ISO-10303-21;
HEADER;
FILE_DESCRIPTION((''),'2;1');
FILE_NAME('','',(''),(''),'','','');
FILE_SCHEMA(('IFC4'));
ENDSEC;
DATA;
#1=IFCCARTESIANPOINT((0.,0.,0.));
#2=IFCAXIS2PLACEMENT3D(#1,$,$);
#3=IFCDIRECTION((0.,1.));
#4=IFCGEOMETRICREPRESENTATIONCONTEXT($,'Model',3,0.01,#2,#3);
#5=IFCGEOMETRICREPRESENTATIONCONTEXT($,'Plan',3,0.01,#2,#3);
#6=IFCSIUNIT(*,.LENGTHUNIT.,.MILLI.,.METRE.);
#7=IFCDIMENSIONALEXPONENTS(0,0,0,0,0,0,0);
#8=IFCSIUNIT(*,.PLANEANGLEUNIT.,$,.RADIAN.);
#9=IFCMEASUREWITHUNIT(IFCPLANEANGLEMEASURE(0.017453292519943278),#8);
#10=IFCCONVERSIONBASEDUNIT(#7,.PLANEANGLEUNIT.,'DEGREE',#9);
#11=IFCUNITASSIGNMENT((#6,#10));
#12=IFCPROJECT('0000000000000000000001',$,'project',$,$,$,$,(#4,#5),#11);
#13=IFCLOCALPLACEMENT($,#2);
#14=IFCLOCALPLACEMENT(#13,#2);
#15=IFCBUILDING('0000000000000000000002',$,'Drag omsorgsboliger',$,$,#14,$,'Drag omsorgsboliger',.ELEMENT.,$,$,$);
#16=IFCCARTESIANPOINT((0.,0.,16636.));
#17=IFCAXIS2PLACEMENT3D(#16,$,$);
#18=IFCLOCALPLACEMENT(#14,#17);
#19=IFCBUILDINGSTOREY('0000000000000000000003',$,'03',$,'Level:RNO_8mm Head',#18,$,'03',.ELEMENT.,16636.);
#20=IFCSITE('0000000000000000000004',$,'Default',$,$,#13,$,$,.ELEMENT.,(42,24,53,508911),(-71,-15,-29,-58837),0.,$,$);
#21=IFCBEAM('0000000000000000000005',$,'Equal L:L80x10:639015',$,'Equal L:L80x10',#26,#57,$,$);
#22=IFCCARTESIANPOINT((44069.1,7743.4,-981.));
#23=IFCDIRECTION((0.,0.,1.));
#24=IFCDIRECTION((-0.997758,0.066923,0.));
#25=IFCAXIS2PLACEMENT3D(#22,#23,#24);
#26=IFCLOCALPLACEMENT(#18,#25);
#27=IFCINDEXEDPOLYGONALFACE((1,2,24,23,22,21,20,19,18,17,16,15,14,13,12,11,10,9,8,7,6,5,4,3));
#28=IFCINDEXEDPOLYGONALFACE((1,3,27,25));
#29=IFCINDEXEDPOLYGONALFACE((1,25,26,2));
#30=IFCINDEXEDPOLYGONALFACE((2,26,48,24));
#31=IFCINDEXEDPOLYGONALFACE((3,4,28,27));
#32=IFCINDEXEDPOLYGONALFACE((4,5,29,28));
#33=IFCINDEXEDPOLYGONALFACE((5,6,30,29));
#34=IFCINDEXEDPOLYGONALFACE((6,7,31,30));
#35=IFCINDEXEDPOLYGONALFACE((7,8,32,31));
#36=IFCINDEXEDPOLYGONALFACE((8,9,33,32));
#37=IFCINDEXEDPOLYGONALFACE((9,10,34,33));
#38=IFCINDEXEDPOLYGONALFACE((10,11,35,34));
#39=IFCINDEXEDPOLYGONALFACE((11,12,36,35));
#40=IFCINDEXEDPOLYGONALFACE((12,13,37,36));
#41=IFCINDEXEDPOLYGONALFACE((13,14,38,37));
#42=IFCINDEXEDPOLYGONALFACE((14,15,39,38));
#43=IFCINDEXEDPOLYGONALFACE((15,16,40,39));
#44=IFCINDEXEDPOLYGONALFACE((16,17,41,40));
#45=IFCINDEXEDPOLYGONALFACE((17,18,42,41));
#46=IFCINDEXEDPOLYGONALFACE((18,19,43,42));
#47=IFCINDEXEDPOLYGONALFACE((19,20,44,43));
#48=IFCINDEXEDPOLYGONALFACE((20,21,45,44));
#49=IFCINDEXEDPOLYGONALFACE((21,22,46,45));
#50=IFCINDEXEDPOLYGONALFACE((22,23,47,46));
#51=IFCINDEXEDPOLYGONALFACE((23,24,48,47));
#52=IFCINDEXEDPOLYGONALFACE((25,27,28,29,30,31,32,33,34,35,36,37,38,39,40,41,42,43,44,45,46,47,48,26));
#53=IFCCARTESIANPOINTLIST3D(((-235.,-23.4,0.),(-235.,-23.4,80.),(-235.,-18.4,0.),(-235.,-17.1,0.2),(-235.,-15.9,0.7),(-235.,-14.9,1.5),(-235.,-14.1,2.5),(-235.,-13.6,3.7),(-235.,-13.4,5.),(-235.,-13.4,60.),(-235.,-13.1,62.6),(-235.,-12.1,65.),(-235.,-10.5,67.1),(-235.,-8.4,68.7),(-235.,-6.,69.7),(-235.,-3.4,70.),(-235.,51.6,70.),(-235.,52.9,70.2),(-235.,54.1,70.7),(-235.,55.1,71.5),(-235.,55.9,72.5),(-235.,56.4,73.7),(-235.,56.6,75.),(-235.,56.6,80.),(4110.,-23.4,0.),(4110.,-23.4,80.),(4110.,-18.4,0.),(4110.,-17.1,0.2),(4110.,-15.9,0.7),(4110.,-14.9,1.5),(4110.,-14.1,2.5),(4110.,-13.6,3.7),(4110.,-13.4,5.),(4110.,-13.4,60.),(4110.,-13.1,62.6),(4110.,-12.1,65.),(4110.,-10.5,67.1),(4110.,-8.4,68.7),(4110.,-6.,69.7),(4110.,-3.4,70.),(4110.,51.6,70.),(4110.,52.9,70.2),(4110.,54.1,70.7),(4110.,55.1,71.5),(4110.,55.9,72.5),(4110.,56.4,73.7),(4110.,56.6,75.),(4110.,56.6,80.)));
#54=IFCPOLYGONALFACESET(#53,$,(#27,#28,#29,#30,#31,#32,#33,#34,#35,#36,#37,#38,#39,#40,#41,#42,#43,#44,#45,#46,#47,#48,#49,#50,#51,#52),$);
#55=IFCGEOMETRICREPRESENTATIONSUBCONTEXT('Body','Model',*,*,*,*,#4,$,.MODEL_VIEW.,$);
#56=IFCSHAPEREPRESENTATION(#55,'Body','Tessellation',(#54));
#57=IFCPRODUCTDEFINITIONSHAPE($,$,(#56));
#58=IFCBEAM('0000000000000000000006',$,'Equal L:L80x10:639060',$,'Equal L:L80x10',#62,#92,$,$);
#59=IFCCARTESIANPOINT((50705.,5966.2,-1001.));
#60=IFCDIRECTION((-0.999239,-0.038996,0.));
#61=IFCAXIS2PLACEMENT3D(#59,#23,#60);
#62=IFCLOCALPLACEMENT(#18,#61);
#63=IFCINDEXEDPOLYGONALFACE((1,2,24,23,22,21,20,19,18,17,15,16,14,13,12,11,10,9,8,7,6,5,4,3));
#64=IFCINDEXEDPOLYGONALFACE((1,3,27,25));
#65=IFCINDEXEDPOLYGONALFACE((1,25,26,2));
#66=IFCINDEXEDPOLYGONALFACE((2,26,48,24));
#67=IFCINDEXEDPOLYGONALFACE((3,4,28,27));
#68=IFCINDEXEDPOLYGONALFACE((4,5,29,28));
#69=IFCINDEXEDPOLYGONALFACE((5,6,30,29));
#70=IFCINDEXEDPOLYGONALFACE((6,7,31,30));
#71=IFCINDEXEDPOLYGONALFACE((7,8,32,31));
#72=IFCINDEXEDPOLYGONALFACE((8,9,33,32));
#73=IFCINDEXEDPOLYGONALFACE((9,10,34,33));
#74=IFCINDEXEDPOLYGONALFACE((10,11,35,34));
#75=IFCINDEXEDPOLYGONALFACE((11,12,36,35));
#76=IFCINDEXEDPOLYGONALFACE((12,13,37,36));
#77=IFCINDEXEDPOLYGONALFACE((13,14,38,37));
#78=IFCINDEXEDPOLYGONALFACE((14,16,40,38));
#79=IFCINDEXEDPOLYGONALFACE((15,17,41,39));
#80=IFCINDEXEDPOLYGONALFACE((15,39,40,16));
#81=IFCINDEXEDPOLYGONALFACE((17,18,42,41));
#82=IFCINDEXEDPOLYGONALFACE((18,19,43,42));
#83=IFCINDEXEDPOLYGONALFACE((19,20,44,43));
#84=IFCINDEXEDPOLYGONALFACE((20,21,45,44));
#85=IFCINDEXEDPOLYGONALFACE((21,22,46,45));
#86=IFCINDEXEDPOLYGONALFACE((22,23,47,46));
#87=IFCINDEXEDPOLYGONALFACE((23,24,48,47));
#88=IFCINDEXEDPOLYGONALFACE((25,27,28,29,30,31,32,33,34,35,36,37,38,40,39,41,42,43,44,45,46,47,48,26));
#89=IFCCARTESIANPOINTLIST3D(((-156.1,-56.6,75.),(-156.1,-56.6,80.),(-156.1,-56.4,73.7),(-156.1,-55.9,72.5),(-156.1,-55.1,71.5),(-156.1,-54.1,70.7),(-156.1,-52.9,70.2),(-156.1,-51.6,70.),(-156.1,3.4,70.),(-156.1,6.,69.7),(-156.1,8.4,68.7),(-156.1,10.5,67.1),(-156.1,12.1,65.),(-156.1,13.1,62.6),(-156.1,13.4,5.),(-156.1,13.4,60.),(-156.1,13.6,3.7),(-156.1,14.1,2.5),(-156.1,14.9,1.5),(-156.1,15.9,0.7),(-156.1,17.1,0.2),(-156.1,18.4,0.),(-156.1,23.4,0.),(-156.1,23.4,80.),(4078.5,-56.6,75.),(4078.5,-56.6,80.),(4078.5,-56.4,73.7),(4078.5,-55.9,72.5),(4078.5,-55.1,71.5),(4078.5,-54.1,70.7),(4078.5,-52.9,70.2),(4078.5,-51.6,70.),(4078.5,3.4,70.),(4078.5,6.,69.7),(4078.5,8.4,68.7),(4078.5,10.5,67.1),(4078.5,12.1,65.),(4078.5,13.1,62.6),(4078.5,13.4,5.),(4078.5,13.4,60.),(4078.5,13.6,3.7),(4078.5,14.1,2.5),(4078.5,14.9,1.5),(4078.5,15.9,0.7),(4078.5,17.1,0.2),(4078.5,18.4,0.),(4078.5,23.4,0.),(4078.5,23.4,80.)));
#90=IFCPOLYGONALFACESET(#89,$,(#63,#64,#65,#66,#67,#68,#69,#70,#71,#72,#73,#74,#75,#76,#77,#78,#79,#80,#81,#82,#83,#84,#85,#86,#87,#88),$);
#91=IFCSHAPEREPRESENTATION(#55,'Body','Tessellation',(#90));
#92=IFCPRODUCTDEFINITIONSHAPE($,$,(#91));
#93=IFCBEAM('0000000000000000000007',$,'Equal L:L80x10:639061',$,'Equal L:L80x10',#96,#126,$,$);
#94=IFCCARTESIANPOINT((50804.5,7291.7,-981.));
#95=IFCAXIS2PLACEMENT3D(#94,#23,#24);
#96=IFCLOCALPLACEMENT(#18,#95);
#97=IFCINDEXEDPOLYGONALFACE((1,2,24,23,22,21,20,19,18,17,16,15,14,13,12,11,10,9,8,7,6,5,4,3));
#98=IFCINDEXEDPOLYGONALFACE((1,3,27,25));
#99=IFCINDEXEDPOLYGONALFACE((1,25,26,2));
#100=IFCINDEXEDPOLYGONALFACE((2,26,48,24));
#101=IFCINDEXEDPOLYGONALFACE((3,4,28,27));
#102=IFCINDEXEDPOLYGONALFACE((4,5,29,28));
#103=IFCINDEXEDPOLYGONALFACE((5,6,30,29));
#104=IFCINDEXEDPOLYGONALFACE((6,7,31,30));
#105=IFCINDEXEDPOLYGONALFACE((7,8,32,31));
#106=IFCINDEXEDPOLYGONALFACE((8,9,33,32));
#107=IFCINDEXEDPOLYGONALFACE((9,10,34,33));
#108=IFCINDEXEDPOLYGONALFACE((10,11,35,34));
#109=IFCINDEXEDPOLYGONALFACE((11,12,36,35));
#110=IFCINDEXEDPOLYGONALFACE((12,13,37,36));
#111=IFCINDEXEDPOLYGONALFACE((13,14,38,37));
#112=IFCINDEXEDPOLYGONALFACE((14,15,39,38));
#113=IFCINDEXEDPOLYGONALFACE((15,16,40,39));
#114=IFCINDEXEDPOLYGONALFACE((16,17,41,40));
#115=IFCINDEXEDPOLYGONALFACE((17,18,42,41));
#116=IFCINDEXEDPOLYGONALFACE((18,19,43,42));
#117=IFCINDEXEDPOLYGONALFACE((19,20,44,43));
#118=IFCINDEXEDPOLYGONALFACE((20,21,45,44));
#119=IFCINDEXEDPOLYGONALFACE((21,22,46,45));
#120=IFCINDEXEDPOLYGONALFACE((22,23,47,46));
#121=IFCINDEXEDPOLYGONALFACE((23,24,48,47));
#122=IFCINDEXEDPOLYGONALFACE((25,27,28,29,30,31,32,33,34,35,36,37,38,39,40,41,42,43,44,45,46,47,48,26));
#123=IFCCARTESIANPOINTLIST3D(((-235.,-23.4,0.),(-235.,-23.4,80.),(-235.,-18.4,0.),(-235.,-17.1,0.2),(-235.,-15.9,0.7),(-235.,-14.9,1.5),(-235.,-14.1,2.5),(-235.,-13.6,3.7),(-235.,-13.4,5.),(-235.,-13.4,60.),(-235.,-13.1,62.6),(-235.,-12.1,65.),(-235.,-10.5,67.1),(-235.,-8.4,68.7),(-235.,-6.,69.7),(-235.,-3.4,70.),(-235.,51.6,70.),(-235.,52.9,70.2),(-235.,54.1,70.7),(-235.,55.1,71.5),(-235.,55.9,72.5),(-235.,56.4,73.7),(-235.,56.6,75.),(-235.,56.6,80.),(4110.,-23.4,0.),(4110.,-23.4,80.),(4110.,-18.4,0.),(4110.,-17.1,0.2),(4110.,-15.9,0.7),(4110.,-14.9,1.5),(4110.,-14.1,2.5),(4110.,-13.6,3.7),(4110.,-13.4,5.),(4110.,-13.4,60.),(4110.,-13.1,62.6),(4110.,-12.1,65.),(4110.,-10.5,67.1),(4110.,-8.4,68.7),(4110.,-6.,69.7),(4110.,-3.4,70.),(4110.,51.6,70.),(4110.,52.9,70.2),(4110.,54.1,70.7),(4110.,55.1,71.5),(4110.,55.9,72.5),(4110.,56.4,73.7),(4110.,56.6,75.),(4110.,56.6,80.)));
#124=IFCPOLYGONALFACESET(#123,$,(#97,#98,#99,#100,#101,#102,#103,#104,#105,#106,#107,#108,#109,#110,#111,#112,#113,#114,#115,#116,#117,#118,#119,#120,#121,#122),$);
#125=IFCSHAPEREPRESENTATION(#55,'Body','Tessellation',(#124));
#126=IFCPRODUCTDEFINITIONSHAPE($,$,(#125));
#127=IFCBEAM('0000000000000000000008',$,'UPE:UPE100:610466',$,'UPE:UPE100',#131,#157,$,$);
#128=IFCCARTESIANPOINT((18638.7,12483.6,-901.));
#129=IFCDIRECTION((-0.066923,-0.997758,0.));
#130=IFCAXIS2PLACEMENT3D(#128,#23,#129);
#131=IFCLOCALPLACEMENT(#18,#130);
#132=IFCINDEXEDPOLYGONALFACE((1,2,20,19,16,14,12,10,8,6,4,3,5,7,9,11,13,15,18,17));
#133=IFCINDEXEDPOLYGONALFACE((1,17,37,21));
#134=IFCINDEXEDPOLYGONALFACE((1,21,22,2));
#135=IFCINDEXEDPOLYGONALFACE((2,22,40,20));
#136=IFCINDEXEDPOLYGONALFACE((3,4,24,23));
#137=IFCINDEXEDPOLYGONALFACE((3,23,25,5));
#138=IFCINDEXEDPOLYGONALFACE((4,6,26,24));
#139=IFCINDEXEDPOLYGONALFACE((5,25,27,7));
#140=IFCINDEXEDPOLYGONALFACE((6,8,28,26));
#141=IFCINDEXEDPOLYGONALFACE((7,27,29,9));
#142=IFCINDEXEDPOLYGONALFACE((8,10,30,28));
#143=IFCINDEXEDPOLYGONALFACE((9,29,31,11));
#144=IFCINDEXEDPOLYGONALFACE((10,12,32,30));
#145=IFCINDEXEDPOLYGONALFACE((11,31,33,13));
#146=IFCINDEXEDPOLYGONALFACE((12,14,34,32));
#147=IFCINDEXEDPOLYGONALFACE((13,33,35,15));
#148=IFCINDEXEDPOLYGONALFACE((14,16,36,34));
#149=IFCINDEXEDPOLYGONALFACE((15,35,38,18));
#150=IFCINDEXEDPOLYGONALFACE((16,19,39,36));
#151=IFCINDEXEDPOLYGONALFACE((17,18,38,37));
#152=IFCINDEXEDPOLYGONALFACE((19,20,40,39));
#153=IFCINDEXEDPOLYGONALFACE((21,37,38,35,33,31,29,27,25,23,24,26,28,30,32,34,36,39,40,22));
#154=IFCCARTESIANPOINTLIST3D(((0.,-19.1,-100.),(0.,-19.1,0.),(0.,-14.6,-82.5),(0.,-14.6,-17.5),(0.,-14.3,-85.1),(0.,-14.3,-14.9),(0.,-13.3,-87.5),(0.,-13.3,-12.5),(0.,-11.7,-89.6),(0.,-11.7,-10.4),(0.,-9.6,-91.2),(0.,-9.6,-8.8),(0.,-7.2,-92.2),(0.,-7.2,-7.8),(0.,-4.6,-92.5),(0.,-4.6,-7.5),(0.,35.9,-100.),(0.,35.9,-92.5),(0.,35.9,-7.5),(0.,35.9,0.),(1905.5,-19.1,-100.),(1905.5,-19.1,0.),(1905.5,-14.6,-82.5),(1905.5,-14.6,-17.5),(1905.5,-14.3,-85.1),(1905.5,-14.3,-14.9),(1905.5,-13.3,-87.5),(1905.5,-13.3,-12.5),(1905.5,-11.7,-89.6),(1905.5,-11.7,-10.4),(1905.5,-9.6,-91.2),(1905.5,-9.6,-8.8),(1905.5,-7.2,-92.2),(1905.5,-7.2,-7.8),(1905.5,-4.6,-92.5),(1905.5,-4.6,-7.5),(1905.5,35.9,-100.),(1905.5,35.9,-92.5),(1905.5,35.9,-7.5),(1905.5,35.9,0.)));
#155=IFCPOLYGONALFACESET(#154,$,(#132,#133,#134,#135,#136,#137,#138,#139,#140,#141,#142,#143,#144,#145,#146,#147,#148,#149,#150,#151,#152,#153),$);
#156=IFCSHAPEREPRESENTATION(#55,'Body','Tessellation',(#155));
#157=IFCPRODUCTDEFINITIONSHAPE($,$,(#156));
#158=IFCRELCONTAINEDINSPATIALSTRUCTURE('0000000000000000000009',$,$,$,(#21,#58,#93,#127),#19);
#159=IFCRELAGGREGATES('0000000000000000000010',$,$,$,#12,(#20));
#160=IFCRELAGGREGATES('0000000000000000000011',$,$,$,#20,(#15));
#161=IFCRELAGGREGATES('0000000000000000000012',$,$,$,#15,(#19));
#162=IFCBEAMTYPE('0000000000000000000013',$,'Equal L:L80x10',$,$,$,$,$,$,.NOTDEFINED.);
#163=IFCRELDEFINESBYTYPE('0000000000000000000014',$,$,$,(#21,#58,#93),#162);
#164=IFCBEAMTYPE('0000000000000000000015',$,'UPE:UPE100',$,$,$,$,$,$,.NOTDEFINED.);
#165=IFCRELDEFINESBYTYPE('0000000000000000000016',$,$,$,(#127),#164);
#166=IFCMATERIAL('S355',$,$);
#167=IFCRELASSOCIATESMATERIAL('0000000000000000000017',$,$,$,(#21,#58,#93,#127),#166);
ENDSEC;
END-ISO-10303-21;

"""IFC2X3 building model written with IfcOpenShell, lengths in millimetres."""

from ifc_helpers import new_model, entity, si_unit, converted_unit, direction, frame, frame_2d, origin, place, context, subcontext, project, spatial, polyline, circle_curve, parameter, trimmed, segment, composite_curve, outline, extrude, material, type_object, element, save


model = new_model("IFC2X3")

# Units and contexts
model_context = context("Model", 3, precision=0.01, world=origin(), true_north=direction((0.0, 1.0)))
plan_context = context("Plan", 3, precision=0.01, world=origin(), true_north=direction((0.0, 1.0)))
body_context = subcontext(model_context, "Body", "Model", "MODEL_VIEW")
ifc_project = project(units=[si_unit("LENGTHUNIT", "METRE", prefix="MILLI"), converted_unit("PLANEANGLEUNIT", "DEGREE", entity("IfcPlaneAngleMeasure", 0.017453292519943278), si_unit("PLANEANGLEUNIT", "RADIAN"), dimensions=[0, 0, 0, 0, 0, 0, 0])], contexts=[model_context, plan_context])

# Site, building, storey
site_placement = place(None, origin())
site = spatial("IfcSite", under=ifc_project, at=site_placement, Name="Default", CompositionType="ELEMENT", RefLatitude=(42, 24, 53, 508911), RefLongitude=(-71, -15, -29, -58837), RefElevation=0.0)
building_placement = place(site_placement, origin())
building = spatial("IfcBuilding", under=site, at=building_placement, Name="Drag omsorgsboliger", LongName="Drag omsorgsboliger", CompositionType="ELEMENT")
storey_placement = place(building_placement, frame((0.0, 0.0, 16636.0)))
storey = spatial("IfcBuildingStorey", under=building, at=storey_placement, Name="03", ObjectType="Level:RNO_8mm Head", LongName="03", CompositionType="ELEMENT", Elevation=16636.0)

# Beams
ifc_material = material(Name="S355")
beam_type_1 = type_object("IfcBeamType", Name="Equal L:L80x10", PredefinedType="NOTDEFINED")
beam_1_placement = place(storey_placement, frame((44069.1, 7743.4, -981.0), z_axis=(0.0, 0.0, 1.0), x_axis=(-0.997758, 0.066923, 0.0)))
element("IfcBeam", 1, at=beam_1_placement, inside=storey, type_object=beam_type_1, material=ifc_material, Name="Equal L:L80x10:639015", ObjectType="Equal L:L80x10", context=body_context, shape_type="SweptSolid", body=[
    extrude(outline(composite_curve([segment(polyline([(-31.1, -31.1), (48.9, -31.1)]), True, "CONTINUOUS"), segment(polyline([(48.9, -31.1), (48.9, -26.1)]), True, "CONTINUOUS"), segment(trimmed(circle_curve(frame_2d((43.9, -26.1), x_axis=(1.0, 0.0)), 5.0), [parameter(0.0)], [parameter(90.0)], True, "PARAMETER"), True, "CONTINUOUS"), segment(polyline([(43.9, -21.1), (-11.1, -21.1)]), True, "CONTINUOUS"), segment(trimmed(circle_curve(frame_2d((-11.1, -11.1), x_axis=(0.0, -1.0)), 10.0), [parameter(270.0)], [parameter(0.0)], True, "PARAMETER"), False, "CONTINUOUS"), segment(polyline([(-21.1, -11.1), (-21.1, 43.9)]), True, "CONTINUOUS"), segment(trimmed(circle_curve(frame_2d((-26.1, 43.9), x_axis=(1.0, 0.0)), 5.0), [parameter(0.0)], [parameter(90.0)], True, "PARAMETER"), True, "CONTINUOUS"), segment(polyline([(-26.1, 48.9), (-31.1, 48.9)]), True, "CONTINUOUS"), segment(polyline([(-31.1, 48.9), (-31.1, -31.1)]), True, "CONTINUOUS")], self_intersect=False)), frame((-235.0, 7.7, 48.9), z_axis=(1.0, 0.0, 0.0), x_axis=(0.0, 0.0, -1.0)), (0.0, 0.0, 1.0), 4345.0),
])
beam_2_placement = place(storey_placement, frame((50705.0, 5966.2, -1001.0), z_axis=(0.0, 0.0, 1.0), x_axis=(-0.999239, -0.038996, 0.0)))
element("IfcBeam", 2, at=beam_2_placement, inside=storey, type_object=beam_type_1, material=ifc_material, Name="Equal L:L80x10:639060", ObjectType="Equal L:L80x10", context=body_context, shape_type="SweptSolid", body=[
    extrude(outline(composite_curve([segment(polyline([(-31.1, -48.9), (-26.1, -48.9)]), True, "CONTINUOUS"), segment(trimmed(circle_curve(frame_2d((-26.1, -43.9), x_axis=(0.0, -1.0)), 5.0), [parameter(0.0)], [parameter(90.0)], True, "PARAMETER"), True, "CONTINUOUS"), segment(polyline([(-21.1, -43.9), (-21.1, 11.1)]), True, "CONTINUOUS"), segment(trimmed(circle_curve(frame_2d((-11.1, 11.1), x_axis=(-1.0, 0.0)), 10.0), [parameter(270.0)], [parameter(0.0)], True, "PARAMETER"), False, "CONTINUOUS"), segment(polyline([(-11.1, 21.1), (43.9, 21.1)]), True, "CONTINUOUS"), segment(trimmed(circle_curve(frame_2d((43.9, 26.1), x_axis=(0.0, -1.0)), 5.0), [parameter(0.0)], [parameter(90.0)], True, "PARAMETER"), True, "CONTINUOUS"), segment(polyline([(48.9, 26.1), (48.9, 31.1)]), True, "CONTINUOUS"), segment(polyline([(48.9, 31.1), (-31.1, 31.1)]), True, "CONTINUOUS"), segment(polyline([(-31.1, 31.1), (-31.1, -48.9)]), True, "CONTINUOUS")], self_intersect=False)), frame((-156.1, -7.7, 48.9), z_axis=(1.0, 0.0, 0.0), x_axis=(0.0, 0.0, -1.0)), (0.0, 0.0, 1.0), 4234.6),
])
beam_3_placement = place(storey_placement, frame((50804.5, 7291.7, -981.0), z_axis=(0.0, 0.0, 1.0), x_axis=(-0.997758, 0.066923, 0.0)))
element("IfcBeam", 3, at=beam_3_placement, inside=storey, type_object=beam_type_1, material=ifc_material, Name="Equal L:L80x10:639061", ObjectType="Equal L:L80x10", context=body_context, shape_type="SweptSolid", body=[
    extrude(outline(composite_curve([segment(polyline([(-31.1, -31.1), (48.9, -31.1)]), True, "CONTINUOUS"), segment(polyline([(48.9, -31.1), (48.9, -26.1)]), True, "CONTINUOUS"), segment(trimmed(circle_curve(frame_2d((43.9, -26.1), x_axis=(1.0, 0.0)), 5.0), [parameter(0.0)], [parameter(90.0)], True, "PARAMETER"), True, "CONTINUOUS"), segment(polyline([(43.9, -21.1), (-11.1, -21.1)]), True, "CONTINUOUS"), segment(trimmed(circle_curve(frame_2d((-11.1, -11.1), x_axis=(0.0, -1.0)), 10.0), [parameter(270.0)], [parameter(0.0)], True, "PARAMETER"), False, "CONTINUOUS"), segment(polyline([(-21.1, -11.1), (-21.1, 43.9)]), True, "CONTINUOUS"), segment(trimmed(circle_curve(frame_2d((-26.1, 43.9), x_axis=(1.0, 0.0)), 5.0), [parameter(0.0)], [parameter(90.0)], True, "PARAMETER"), True, "CONTINUOUS"), segment(polyline([(-26.1, 48.9), (-31.1, 48.9)]), True, "CONTINUOUS"), segment(polyline([(-31.1, 48.9), (-31.1, -31.1)]), True, "CONTINUOUS")], self_intersect=False)), frame((-235.0, 7.7, 48.9), z_axis=(1.0, 0.0, 0.0), x_axis=(0.0, 0.0, -1.0)), (0.0, 0.0, 1.0), 4345.0),
])
beam_type_2 = type_object("IfcBeamType", Name="UPE:UPE100", PredefinedType="NOTDEFINED")
beam_4_placement = place(storey_placement, frame((18638.7, 12483.6, -901.0), z_axis=(0.0, 0.0, 1.0), x_axis=(-0.066923, -0.997758, 0.0)))
element("IfcBeam", 4, at=beam_4_placement, inside=storey, type_object=beam_type_2, material=ifc_material, Name="UPE:UPE100:610466", ObjectType="UPE:UPE100", context=body_context, shape_type="SweptSolid", body=[
    extrude(outline(composite_curve([segment(polyline([(-50.0, -25.8), (50.0, -25.8)]), True, "CONTINUOUS"), segment(polyline([(50.0, -25.8), (50.0, 29.2)]), True, "CONTINUOUS"), segment(polyline([(50.0, 29.2), (42.5, 29.2)]), True, "CONTINUOUS"), segment(polyline([(42.5, 29.2), (42.5, -11.3)]), True, "CONTINUOUS"), segment(trimmed(circle_curve(frame_2d((32.5, -11.3), x_axis=(1.0, 0.0)), 10.0), [parameter(270.0)], [parameter(0.0)], True, "PARAMETER"), False, "CONTINUOUS"), segment(polyline([(32.5, -21.3), (-32.5, -21.3)]), True, "CONTINUOUS"), segment(trimmed(circle_curve(frame_2d((-32.5, -11.3), x_axis=(0.0, -1.0)), 10.0), [parameter(270.0)], [parameter(0.0)], True, "PARAMETER"), False, "CONTINUOUS"), segment(polyline([(-42.5, -11.3), (-42.5, 29.2)]), True, "CONTINUOUS"), segment(polyline([(-42.5, 29.2), (-50.0, 29.2)]), True, "CONTINUOUS"), segment(polyline([(-50.0, 29.2), (-50.0, -25.8)]), True, "CONTINUOUS")], self_intersect=False)), frame((0.0, 6.7, -50.0), z_axis=(1.0, 0.0, 0.0), x_axis=(0.0, 0.0, -1.0)), (0.0, 0.0, 1.0), 1905.5),
])

save(model, "model.ifc")
